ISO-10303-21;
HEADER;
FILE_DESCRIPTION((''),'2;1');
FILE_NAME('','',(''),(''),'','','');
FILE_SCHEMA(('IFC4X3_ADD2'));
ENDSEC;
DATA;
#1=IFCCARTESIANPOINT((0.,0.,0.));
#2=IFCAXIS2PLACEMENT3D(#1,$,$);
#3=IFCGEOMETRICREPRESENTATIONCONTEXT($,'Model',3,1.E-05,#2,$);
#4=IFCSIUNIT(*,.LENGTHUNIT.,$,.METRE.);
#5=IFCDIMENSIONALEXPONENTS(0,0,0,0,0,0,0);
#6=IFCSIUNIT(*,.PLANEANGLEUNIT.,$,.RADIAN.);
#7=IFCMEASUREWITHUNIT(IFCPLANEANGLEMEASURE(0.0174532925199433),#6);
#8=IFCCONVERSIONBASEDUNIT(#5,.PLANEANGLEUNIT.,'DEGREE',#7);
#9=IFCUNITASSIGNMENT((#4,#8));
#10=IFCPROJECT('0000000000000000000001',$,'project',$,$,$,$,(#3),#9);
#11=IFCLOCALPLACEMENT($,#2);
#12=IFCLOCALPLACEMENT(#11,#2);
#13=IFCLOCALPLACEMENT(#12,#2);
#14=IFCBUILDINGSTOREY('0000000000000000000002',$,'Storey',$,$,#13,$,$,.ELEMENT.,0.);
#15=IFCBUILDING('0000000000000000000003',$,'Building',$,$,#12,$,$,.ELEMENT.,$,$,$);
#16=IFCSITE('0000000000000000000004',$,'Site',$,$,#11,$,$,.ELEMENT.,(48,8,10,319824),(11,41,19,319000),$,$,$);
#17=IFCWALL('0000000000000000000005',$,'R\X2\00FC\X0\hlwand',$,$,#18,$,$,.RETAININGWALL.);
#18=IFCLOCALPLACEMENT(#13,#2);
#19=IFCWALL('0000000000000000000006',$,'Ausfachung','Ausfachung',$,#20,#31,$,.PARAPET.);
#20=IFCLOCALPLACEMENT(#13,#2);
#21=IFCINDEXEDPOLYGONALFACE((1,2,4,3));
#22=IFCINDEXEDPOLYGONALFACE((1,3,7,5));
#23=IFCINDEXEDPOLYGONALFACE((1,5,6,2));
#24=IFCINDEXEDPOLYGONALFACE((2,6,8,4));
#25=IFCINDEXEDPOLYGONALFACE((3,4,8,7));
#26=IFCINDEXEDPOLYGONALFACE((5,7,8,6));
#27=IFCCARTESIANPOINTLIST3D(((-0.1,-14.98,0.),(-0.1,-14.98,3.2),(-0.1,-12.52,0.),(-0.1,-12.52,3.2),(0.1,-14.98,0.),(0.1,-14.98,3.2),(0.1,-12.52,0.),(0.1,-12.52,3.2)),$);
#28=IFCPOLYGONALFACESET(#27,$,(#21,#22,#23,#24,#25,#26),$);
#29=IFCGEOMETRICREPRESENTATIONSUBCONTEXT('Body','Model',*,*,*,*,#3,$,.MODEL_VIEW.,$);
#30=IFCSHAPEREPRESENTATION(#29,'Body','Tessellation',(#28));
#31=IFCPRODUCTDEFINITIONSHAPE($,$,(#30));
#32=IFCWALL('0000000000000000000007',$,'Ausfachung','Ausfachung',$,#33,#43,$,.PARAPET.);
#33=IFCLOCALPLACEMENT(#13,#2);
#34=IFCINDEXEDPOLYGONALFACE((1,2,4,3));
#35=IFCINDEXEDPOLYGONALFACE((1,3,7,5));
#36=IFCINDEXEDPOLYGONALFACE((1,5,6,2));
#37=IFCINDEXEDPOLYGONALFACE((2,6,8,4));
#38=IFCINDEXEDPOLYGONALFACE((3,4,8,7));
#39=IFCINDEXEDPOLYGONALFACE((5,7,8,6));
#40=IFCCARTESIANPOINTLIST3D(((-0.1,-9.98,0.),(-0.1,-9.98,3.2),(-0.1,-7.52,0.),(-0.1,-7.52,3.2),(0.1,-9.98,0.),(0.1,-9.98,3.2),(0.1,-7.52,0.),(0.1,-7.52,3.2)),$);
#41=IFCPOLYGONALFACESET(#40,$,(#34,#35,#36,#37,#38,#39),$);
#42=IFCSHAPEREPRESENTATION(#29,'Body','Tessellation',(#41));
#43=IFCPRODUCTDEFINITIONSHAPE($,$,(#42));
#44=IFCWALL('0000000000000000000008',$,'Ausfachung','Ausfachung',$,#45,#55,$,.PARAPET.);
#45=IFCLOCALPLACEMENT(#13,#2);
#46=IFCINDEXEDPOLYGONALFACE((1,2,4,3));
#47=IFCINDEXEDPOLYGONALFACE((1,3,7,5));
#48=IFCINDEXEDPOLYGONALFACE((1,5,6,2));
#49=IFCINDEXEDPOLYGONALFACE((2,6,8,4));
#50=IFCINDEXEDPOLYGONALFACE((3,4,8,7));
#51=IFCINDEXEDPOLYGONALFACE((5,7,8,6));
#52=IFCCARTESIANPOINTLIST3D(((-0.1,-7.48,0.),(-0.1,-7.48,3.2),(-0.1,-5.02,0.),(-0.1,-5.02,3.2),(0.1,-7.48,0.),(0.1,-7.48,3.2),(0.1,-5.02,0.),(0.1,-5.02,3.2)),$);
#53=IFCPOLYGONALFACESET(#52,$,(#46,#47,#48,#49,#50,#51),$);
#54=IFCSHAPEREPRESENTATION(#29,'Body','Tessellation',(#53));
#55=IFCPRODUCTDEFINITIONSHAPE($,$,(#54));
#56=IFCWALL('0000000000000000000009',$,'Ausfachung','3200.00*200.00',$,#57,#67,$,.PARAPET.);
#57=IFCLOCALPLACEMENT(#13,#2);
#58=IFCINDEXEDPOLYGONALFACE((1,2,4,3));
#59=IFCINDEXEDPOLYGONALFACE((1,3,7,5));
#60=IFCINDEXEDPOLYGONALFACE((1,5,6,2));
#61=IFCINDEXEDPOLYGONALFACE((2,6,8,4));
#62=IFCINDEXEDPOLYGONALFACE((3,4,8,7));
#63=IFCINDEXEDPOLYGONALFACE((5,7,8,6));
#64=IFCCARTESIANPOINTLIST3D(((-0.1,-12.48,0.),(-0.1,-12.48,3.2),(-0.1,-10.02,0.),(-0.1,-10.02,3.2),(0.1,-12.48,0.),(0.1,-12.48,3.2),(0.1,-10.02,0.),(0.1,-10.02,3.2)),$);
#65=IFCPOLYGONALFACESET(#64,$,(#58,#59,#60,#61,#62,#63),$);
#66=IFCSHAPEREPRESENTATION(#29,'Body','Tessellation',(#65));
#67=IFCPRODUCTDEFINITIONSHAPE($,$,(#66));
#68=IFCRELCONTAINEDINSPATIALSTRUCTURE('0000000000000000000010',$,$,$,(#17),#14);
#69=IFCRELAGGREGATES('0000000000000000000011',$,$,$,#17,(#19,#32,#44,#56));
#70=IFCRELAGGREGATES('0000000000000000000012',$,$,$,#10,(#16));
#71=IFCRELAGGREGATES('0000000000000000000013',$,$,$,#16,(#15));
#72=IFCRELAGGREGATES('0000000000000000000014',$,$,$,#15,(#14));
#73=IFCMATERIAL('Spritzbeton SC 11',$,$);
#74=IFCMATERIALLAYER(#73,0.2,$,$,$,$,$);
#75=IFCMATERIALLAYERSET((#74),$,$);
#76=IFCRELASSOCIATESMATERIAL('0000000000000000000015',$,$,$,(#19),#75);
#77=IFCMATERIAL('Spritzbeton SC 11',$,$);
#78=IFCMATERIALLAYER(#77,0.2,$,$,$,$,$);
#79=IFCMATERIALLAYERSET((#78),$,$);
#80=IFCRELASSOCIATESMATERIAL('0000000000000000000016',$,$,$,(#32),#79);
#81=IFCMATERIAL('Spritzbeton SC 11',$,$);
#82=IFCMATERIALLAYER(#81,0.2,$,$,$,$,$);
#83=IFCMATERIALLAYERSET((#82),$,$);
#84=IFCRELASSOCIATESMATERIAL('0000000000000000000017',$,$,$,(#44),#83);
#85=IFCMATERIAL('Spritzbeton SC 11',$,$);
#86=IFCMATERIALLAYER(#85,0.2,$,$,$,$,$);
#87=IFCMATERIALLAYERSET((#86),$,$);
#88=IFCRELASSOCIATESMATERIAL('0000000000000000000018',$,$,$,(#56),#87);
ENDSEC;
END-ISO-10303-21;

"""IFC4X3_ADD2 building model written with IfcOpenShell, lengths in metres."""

from ifc_helpers import new_model, entity, si_unit, converted_unit, frame, frame_2d, origin, origin_with_axes, place, context, subcontext, project, spatial, rectangle, extrude, material, layer, layer_set, layer_usage, element, aggregate, save


model = new_model("IFC4X3_ADD2")

# Units and contexts
model_context = context("Model", 3, precision=1e-05, world=origin())
body_context = subcontext(model_context, "Body", "Model", "MODEL_VIEW")
ifc_project = project(units=[si_unit("LENGTHUNIT", "METRE"), converted_unit("PLANEANGLEUNIT", "DEGREE", entity("IfcPlaneAngleMeasure", 0.0174532925199433), si_unit("PLANEANGLEUNIT", "RADIAN"), dimensions=[0, 0, 0, 0, 0, 0, 0])], contexts=[model_context])

# Site, building, storey
site_placement = place(None, origin())
site = spatial("IfcSite", under=ifc_project, at=site_placement, Name="Site", CompositionType="ELEMENT", RefLatitude=(48, 8, 10, 319824), RefLongitude=(11, 41, 19, 319000))
building_placement = place(site_placement, origin())
building = spatial("IfcBuilding", under=site, at=building_placement, Name="Building", CompositionType="ELEMENT")
storey_placement = place(building_placement, origin())
storey = spatial("IfcBuildingStorey", under=building, at=storey_placement, Name="Storey", CompositionType="ELEMENT", Elevation=0.0)

# Walls
wall_1_placement = place(storey_placement, origin())
wall_1 = element("IfcWall", 1, at=wall_1_placement, inside=storey, Name="Rühlwand", PredefinedType="RETAININGWALL")
ifc_material_1 = material(Name="Spritzbeton SC 11")
ifc_layer_1 = layer(ifc_material_1, 0.2)
ifc_layer_set_1 = layer_set([ifc_layer_1])
ifc_layer_usage_1 = layer_usage(ifc_layer_set_1, "AXIS2", "POSITIVE", 0.0)
wall_2_placement = place(wall_1_placement, frame((-0.1, -12.52, 0.0), z_axis=(0.0, 0.0, 1.0), x_axis=(0.0, -1.0, 0.0)))
wall_2 = element("IfcWall", 2, at=wall_2_placement, material=ifc_layer_usage_1, Name="Ausfachung", Description="Ausfachung", PredefinedType="PARAPET", context=body_context, shape_type="SweptSolid", body=[
    extrude(rectangle(XDim=2.46, YDim=0.2, at=frame_2d((1.23, 0.1), x_axis=(1.0, 0.0))), origin_with_axes(), (0.0, 0.0, 1.0), 3.2),
])
ifc_material_2 = material(Name="Spritzbeton SC 11")
ifc_layer_2 = layer(ifc_material_2, 0.2)
ifc_layer_set_2 = layer_set([ifc_layer_2])
ifc_layer_usage_2 = layer_usage(ifc_layer_set_2, "AXIS2", "POSITIVE", 0.0)
wall_3_placement = place(wall_1_placement, frame((-0.1, -7.52, 0.0), z_axis=(0.0, 0.0, 1.0), x_axis=(0.0, -1.0, 0.0)))
wall_3 = element("IfcWall", 3, at=wall_3_placement, material=ifc_layer_usage_2, Name="Ausfachung", Description="Ausfachung", PredefinedType="PARAPET", context=body_context, shape_type="SweptSolid", body=[
    extrude(rectangle(XDim=2.46, YDim=0.2, at=frame_2d((1.23, 0.1), x_axis=(1.0, 0.0))), origin_with_axes(), (0.0, 0.0, 1.0), 3.2),
])
ifc_material_3 = material(Name="Spritzbeton SC 11")
ifc_layer_3 = layer(ifc_material_3, 0.2)
ifc_layer_set_3 = layer_set([ifc_layer_3])
ifc_layer_usage_3 = layer_usage(ifc_layer_set_3, "AXIS2", "POSITIVE", 0.0)
wall_4_placement = place(wall_1_placement, frame((-0.1, -5.02, 0.0), z_axis=(0.0, 0.0, 1.0), x_axis=(0.0, -1.0, 0.0)))
wall_4 = element("IfcWall", 4, at=wall_4_placement, material=ifc_layer_usage_3, Name="Ausfachung", Description="Ausfachung", PredefinedType="PARAPET", context=body_context, shape_type="SweptSolid", body=[
    extrude(rectangle(XDim=2.46, YDim=0.2, at=frame_2d((1.23, 0.1), x_axis=(1.0, 0.0))), origin_with_axes(), (0.0, 0.0, 1.0), 3.2),
])
ifc_material_4 = material(Name="Spritzbeton SC 11")
ifc_layer_4 = layer(ifc_material_4, 0.2)
ifc_layer_set_4 = layer_set([ifc_layer_4])
ifc_layer_usage_4 = layer_usage(ifc_layer_set_4, "AXIS2", "POSITIVE", 0.0)
wall_5_placement = place(wall_1_placement, frame((-0.1, -10.02, 0.0), z_axis=(0.0, 0.0, 1.0), x_axis=(0.0, -1.0, 0.0)))
wall_5 = element("IfcWall", 5, at=wall_5_placement, material=ifc_layer_usage_4, Name="Ausfachung", Description="3200.00*200.00", PredefinedType="PARAPET", context=body_context, shape_type="SweptSolid", body=[
    extrude(rectangle(XDim=2.46, YDim=0.2, at=frame_2d((1.23, 0.1), x_axis=(1.0, 0.0))), origin_with_axes(), (0.0, 0.0, 1.0), 3.2),
])
aggregate(wall_1, [wall_2, wall_3, wall_4, wall_5])

save(model, "model.ifc")
